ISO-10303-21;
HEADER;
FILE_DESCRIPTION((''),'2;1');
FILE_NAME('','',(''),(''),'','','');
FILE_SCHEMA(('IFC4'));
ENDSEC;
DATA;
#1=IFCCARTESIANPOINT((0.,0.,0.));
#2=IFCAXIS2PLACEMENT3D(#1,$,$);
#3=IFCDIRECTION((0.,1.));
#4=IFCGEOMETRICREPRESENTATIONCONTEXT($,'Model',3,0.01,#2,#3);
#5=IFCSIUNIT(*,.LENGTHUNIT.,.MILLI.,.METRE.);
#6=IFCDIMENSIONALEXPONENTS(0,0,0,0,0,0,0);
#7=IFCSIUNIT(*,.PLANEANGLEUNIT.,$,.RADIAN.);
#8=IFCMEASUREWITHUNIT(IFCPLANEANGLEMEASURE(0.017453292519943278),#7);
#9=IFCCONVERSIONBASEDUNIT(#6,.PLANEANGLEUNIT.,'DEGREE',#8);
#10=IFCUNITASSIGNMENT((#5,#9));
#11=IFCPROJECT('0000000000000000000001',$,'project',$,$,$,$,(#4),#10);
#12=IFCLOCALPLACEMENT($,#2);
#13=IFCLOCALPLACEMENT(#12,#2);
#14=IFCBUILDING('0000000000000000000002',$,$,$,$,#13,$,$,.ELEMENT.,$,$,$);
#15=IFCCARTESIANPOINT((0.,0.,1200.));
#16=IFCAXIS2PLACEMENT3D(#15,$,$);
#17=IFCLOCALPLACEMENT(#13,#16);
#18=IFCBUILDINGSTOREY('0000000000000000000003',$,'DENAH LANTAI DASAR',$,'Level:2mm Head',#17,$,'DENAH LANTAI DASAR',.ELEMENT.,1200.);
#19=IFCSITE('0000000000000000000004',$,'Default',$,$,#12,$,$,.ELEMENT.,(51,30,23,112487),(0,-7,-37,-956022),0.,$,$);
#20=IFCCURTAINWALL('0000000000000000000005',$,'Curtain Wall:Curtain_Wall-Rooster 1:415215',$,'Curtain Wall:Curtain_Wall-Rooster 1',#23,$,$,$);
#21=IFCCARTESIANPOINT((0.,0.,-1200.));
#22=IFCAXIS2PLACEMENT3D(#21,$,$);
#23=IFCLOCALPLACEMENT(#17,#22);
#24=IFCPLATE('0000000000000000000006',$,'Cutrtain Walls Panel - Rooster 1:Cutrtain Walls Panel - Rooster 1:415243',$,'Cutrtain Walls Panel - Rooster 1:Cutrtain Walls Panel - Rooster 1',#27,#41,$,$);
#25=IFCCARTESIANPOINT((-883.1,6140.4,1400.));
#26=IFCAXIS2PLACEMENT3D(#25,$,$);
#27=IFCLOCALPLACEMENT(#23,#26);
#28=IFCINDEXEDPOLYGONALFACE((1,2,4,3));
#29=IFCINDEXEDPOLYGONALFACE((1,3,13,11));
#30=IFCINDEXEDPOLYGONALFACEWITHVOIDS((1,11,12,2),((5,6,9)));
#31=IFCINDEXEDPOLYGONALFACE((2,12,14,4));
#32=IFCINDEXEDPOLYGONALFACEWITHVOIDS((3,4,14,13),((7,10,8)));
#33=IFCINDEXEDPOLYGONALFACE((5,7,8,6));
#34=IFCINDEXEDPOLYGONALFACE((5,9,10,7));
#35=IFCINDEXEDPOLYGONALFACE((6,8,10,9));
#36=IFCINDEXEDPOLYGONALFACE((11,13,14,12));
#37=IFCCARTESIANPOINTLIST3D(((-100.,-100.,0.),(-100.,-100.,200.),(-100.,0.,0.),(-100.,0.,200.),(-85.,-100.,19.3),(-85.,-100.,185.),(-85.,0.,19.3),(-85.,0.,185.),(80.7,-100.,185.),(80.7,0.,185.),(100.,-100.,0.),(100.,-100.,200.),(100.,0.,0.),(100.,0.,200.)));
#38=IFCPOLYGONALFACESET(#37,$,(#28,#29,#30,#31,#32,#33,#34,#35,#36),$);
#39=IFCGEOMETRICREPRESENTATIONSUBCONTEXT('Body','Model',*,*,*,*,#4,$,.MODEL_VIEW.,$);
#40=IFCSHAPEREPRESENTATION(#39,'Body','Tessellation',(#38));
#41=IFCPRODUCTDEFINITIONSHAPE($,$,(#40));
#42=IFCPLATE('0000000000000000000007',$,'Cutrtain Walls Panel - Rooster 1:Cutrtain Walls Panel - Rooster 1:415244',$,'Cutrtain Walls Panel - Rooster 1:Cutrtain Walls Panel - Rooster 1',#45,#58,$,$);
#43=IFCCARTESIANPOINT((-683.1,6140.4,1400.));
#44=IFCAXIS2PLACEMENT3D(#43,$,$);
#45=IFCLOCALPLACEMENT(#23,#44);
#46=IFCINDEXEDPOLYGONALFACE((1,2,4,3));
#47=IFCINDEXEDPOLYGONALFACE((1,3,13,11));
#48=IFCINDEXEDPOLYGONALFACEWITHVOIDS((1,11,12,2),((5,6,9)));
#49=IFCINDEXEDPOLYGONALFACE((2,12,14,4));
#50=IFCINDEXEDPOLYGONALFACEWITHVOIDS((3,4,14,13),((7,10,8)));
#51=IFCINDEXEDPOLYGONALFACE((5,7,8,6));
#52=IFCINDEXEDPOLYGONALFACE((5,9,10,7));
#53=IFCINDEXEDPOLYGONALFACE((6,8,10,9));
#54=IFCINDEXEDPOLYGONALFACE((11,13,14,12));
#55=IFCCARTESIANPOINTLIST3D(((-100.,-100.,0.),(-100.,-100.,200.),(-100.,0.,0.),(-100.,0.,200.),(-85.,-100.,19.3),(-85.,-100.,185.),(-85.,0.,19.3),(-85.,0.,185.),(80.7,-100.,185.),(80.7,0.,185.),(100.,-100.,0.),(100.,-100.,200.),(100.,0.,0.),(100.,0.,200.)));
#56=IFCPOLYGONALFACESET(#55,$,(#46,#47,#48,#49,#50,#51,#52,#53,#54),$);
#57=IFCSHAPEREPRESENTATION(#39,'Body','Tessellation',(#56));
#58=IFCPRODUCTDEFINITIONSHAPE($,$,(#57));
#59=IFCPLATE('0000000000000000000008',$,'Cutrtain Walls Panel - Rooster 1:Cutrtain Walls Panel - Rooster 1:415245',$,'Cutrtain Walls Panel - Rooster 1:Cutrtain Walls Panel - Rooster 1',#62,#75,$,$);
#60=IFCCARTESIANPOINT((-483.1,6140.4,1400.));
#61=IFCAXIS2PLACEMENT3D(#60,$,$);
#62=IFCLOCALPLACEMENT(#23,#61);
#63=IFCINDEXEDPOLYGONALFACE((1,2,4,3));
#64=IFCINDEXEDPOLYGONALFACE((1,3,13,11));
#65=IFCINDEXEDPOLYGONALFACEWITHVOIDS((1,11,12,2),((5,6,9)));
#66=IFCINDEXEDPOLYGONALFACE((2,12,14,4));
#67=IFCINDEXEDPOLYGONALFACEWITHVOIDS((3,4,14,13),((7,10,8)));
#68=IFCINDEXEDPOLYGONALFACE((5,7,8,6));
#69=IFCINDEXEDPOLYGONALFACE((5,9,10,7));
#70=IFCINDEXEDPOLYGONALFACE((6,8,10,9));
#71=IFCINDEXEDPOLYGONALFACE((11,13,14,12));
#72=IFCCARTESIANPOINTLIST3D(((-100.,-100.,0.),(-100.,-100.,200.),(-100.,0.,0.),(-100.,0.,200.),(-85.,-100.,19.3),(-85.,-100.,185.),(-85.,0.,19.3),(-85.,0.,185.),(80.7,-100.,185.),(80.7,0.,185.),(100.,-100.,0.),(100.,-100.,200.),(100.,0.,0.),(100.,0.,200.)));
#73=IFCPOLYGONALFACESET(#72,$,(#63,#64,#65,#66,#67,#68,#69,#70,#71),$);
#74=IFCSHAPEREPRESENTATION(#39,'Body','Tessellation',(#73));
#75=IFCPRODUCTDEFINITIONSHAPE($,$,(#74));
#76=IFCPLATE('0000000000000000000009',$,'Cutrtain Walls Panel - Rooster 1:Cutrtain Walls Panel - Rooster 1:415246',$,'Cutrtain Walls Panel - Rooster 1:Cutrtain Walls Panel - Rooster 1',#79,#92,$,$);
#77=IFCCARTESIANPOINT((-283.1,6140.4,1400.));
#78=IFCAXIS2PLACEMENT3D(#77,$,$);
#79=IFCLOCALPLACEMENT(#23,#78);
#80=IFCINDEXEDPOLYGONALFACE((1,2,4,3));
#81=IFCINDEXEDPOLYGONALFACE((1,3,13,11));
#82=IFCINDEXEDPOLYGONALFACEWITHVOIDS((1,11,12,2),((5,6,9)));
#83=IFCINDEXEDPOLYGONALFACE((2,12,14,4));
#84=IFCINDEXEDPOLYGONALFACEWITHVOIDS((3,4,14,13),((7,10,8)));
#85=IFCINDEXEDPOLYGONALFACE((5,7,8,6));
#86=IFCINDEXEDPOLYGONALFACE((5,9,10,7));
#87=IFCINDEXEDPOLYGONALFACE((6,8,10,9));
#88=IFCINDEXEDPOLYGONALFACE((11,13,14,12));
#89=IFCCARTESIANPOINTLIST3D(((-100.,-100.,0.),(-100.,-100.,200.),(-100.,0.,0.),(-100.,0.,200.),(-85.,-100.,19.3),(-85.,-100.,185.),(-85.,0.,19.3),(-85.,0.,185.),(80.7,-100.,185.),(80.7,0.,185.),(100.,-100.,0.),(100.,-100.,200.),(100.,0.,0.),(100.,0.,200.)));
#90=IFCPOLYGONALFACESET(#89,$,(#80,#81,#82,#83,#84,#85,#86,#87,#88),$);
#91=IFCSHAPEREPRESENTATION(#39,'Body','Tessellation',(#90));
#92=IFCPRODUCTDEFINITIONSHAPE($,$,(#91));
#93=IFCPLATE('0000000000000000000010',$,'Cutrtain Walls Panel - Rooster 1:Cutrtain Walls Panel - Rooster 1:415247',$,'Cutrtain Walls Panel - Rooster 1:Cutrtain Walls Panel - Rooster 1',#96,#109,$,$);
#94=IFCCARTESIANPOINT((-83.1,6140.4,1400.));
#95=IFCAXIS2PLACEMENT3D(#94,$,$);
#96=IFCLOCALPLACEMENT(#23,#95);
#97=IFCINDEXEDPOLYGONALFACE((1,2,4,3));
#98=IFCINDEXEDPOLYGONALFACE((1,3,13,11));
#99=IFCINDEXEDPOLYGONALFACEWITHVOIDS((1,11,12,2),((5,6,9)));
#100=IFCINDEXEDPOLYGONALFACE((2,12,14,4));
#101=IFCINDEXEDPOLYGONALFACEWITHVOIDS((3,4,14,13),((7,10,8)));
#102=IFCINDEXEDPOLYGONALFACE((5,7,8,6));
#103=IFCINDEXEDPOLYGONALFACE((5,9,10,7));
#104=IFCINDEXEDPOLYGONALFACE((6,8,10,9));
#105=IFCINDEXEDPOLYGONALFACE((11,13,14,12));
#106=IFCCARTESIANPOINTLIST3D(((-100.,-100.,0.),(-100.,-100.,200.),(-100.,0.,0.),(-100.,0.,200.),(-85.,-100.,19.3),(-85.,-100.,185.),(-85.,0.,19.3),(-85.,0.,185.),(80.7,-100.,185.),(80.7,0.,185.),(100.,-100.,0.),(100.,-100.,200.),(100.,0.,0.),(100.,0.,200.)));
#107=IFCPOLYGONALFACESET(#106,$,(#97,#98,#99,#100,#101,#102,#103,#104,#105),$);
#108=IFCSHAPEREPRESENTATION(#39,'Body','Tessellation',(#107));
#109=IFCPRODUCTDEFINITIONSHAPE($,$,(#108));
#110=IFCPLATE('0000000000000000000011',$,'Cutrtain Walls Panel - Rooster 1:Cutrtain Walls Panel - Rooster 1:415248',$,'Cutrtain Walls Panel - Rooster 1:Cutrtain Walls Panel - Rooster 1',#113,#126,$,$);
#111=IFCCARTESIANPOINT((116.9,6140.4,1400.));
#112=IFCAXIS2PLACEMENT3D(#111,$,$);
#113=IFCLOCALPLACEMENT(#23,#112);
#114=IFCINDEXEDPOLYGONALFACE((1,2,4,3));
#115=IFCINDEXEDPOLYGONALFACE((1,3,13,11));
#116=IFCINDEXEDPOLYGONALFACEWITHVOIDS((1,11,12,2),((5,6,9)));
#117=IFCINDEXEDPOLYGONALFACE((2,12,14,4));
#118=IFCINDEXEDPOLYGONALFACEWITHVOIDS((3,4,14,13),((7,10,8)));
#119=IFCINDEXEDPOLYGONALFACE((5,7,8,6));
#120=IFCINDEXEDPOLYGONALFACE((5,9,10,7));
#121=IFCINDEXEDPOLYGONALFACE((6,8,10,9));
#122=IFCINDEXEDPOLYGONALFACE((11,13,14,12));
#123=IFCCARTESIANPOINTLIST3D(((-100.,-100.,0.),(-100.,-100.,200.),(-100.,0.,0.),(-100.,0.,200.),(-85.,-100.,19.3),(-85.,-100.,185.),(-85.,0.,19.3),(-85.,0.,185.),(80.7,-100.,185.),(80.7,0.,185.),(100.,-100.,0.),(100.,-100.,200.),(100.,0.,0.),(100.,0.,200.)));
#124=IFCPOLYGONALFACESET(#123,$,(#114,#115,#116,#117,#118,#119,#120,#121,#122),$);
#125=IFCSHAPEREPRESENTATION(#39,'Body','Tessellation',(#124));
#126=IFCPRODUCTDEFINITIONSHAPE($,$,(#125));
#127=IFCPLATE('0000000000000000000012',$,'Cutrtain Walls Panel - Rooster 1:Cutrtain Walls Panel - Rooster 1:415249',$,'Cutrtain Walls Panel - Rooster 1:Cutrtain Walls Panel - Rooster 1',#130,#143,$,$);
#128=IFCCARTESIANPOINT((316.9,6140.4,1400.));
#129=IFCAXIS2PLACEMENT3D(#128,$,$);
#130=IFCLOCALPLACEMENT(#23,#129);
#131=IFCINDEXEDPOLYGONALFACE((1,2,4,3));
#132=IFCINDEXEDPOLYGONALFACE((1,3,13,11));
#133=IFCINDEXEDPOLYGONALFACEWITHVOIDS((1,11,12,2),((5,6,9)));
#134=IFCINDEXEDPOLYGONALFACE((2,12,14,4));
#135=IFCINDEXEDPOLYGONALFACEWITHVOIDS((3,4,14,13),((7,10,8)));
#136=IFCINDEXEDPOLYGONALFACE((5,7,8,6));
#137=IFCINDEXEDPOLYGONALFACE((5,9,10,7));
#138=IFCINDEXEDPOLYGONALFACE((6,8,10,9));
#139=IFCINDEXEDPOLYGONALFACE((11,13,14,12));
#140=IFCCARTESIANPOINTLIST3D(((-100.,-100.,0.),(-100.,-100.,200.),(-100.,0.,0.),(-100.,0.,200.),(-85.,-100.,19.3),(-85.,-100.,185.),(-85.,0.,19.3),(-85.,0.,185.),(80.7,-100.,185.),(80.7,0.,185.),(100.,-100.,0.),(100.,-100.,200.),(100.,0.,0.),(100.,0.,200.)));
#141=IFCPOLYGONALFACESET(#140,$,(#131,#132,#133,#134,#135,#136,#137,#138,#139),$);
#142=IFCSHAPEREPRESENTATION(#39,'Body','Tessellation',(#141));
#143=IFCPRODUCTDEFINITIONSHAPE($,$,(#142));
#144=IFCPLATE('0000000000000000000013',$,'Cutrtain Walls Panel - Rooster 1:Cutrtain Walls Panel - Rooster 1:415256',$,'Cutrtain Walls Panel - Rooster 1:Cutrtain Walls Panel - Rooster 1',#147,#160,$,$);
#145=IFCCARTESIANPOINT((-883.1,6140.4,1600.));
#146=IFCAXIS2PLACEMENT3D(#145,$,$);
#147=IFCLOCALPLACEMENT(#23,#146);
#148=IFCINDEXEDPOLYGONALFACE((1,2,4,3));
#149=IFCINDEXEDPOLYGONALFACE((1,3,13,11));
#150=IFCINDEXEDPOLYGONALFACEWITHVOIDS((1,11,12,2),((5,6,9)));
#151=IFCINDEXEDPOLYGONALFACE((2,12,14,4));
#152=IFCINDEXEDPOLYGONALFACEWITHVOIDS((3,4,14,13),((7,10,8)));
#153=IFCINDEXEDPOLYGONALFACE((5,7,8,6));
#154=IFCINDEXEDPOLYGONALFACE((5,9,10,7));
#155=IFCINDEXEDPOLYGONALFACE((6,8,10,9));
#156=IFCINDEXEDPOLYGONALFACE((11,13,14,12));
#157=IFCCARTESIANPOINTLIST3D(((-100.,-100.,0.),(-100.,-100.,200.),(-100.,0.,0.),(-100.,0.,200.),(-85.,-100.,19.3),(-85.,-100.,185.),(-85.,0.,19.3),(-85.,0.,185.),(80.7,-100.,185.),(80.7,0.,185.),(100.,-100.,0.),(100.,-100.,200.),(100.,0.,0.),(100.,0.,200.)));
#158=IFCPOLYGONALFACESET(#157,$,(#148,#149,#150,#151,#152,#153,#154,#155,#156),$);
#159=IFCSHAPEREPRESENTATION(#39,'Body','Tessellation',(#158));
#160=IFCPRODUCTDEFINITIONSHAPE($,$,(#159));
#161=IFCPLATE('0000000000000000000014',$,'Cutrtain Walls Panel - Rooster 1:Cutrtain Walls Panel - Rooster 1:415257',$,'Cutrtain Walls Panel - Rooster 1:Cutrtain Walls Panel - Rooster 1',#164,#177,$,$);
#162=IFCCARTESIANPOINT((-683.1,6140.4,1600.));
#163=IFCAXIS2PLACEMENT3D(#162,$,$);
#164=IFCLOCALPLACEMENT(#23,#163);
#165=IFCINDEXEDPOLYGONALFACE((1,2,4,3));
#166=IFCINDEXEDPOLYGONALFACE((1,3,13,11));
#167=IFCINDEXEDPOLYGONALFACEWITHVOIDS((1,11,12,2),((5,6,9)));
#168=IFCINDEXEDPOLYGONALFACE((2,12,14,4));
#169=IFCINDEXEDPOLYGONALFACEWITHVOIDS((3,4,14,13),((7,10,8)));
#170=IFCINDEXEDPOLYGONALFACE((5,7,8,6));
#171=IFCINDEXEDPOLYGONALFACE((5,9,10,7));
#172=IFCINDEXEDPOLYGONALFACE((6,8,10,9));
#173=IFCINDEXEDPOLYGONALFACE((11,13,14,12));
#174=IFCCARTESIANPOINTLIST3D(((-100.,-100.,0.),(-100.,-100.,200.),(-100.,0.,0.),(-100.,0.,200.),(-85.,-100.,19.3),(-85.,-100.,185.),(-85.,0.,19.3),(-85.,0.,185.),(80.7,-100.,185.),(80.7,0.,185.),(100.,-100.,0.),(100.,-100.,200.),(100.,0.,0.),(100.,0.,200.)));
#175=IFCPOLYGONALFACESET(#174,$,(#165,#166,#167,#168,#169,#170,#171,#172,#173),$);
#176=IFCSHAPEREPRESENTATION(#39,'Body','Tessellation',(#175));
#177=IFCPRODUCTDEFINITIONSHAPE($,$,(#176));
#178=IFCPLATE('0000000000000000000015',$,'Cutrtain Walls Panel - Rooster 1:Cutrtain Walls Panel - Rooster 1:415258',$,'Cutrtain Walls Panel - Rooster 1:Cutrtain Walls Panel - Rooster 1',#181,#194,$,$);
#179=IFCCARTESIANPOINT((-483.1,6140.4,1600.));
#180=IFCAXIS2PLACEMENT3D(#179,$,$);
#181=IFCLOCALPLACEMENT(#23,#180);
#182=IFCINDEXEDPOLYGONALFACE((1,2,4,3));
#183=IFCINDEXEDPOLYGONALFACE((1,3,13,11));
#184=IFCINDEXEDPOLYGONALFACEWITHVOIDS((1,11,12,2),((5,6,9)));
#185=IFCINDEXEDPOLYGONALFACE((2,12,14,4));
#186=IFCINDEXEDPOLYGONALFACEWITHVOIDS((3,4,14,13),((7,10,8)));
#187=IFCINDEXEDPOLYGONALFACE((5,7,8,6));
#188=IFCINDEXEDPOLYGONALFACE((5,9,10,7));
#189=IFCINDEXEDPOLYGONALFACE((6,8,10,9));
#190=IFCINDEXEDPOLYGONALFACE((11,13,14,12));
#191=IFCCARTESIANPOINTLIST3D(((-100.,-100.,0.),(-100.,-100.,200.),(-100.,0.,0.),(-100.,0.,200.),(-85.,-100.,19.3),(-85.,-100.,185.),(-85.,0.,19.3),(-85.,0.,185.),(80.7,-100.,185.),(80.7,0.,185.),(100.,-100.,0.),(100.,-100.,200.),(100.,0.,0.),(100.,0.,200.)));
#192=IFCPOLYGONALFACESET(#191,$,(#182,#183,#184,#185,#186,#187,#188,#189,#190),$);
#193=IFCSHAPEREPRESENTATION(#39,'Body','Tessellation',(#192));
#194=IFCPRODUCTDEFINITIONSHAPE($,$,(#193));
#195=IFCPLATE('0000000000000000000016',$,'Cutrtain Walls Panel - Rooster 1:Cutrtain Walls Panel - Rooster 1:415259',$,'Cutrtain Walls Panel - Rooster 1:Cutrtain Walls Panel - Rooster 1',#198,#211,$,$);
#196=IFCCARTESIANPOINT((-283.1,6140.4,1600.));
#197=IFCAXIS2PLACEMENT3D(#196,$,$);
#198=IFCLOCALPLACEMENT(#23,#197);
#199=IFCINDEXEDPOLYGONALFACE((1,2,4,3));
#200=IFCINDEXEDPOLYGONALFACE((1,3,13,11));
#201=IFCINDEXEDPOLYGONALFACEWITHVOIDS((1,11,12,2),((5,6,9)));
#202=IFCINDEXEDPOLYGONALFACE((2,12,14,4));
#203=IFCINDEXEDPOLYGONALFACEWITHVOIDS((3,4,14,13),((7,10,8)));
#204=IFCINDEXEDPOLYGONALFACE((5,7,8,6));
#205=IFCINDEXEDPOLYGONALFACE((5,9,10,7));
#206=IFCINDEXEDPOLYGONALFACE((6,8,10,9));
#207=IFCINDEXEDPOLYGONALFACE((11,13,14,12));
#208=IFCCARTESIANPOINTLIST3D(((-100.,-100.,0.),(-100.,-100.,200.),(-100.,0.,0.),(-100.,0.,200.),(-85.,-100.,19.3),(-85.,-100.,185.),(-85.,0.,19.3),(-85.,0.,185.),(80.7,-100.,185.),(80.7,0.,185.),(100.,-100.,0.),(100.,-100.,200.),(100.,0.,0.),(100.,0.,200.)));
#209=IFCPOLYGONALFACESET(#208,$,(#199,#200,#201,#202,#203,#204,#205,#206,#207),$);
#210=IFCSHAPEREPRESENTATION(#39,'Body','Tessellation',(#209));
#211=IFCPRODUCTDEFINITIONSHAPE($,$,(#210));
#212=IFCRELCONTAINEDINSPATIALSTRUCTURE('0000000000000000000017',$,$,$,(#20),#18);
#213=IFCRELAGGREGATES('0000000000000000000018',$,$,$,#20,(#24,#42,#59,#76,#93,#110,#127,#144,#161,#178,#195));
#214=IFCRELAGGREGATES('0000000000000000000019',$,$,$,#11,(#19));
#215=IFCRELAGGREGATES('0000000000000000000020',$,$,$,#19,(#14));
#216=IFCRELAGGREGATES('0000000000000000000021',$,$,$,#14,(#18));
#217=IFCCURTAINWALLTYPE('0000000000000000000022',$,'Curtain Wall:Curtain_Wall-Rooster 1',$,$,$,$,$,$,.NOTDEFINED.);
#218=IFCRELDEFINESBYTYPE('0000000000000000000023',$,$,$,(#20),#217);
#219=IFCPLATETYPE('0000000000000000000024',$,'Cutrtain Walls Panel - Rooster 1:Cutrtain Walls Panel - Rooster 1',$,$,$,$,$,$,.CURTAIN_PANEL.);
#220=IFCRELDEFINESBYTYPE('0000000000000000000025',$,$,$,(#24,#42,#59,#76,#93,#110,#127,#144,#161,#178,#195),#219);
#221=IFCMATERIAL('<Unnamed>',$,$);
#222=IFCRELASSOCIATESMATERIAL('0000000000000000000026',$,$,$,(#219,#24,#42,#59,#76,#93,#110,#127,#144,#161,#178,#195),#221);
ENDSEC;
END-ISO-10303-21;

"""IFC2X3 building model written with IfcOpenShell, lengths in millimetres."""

from ifc_helpers import new_model, entity, si_unit, converted_unit, direction, frame, origin, place, context, subcontext, project, spatial, polyline, outline, extrude, source, transform, mapped, material, type_object, type_shapes, element, aggregate, save


model = new_model("IFC2X3")

# Units and contexts
model_context = context("Model", 3, precision=0.01, world=origin(), true_north=direction((0.0, 1.0)))
body_context = subcontext(model_context, "Body", "Model", "MODEL_VIEW")
ifc_project = project(units=[si_unit("LENGTHUNIT", "METRE", prefix="MILLI"), converted_unit("PLANEANGLEUNIT", "DEGREE", entity("IfcPlaneAngleMeasure", 0.017453292519943278), si_unit("PLANEANGLEUNIT", "RADIAN"), dimensions=[0, 0, 0, 0, 0, 0, 0])], contexts=[model_context])

# Site, building, storey
site_placement = place(None, origin())
site = spatial("IfcSite", under=ifc_project, at=site_placement, Name="Default", CompositionType="ELEMENT", RefLatitude=(51, 30, 23, 112487), RefLongitude=(0, -7, -37, -956022), RefElevation=0.0)
building_placement = place(site_placement, origin())
building = spatial("IfcBuilding", under=site, at=building_placement, CompositionType="ELEMENT")
storey_placement = place(building_placement, frame((0.0, 0.0, 1200.0)))
storey = spatial("IfcBuildingStorey", under=building, at=storey_placement, Name="DENAH LANTAI DASAR", ObjectType="Level:2mm Head", LongName="DENAH LANTAI DASAR", CompositionType="ELEMENT", Elevation=1200.0)

# Curtain wall, plates
curtain_wall_type = type_object("IfcCurtainWallType", Name="Curtain Wall:Curtain_Wall-Rooster 1", PredefinedType="NOTDEFINED")
ifc_material_1 = material(Name="<Unnamed>")
curtain_wall_1_placement = place(storey_placement, frame((0.0, 0.0, -1200.0)))
curtain_wall_1 = element("IfcCurtainWall", 1, at=curtain_wall_1_placement, inside=storey, type_object=curtain_wall_type, Name="Curtain Wall:Curtain_Wall-Rooster 1:415215", ObjectType="Curtain Wall:Curtain_Wall-Rooster 1")
plate_type_1 = type_object("IfcPlateType", Name="Cutrtain Walls Panel - Rooster 1:Cutrtain Walls Panel - Rooster 1", PredefinedType="CURTAIN_PANEL", material=ifc_material_1)
shared_shape_1 = source(origin(), body_context, "Body", "SweptSolid", [
    extrude(outline(polyline([(-100.0, -100.0), (100.0, -100.0), (100.0, 100.0), (-100.0, 100.0), (-100.0, -100.0)]), holes=[polyline([(80.7, 85.0), (-85.0, -80.7), (-85.0, 85.0), (80.7, 85.0)])]), frame((0.0, -100.0, 100.0), z_axis=(0.0, 1.0, 0.0), x_axis=(0.0, 0.0, -1.0)), (0.0, 0.0, 1.0), 100.0),
])
type_shapes(plate_type_1, [shared_shape_1])
plate_1_placement = place(curtain_wall_1_placement, frame((-883.1, 6140.4, 1400.0)))
plate_1 = element("IfcPlate", 2, at=plate_1_placement, type_object=plate_type_1, material=ifc_material_1, Name="Cutrtain Walls Panel - Rooster 1:Cutrtain Walls Panel - Rooster 1:415243", ObjectType="Cutrtain Walls Panel - Rooster 1:Cutrtain Walls Panel - Rooster 1", context=body_context, shape_type="MappedRepresentation", body=[
    mapped(shared_shape_1, transform((0.0, 0.0, 0.0), scale=1.0)),
])
plate_2_placement = place(curtain_wall_1_placement, frame((-683.1, 6140.4, 1400.0)))
plate_2 = element("IfcPlate", 3, at=plate_2_placement, type_object=plate_type_1, material=ifc_material_1, Name="Cutrtain Walls Panel - Rooster 1:Cutrtain Walls Panel - Rooster 1:415244", ObjectType="Cutrtain Walls Panel - Rooster 1:Cutrtain Walls Panel - Rooster 1", context=body_context, shape_type="MappedRepresentation", body=[
    mapped(shared_shape_1, transform((0.0, 0.0, 0.0), scale=1.0)),
])
plate_3_placement = place(curtain_wall_1_placement, frame((-483.1, 6140.4, 1400.0)))
plate_3 = element("IfcPlate", 4, at=plate_3_placement, type_object=plate_type_1, material=ifc_material_1, Name="Cutrtain Walls Panel - Rooster 1:Cutrtain Walls Panel - Rooster 1:415245", ObjectType="Cutrtain Walls Panel - Rooster 1:Cutrtain Walls Panel - Rooster 1", context=body_context, shape_type="MappedRepresentation", body=[
    mapped(shared_shape_1, transform((0.0, 0.0, 0.0), scale=1.0)),
])
plate_4_placement = place(curtain_wall_1_placement, frame((-283.1, 6140.4, 1400.0)))
plate_4 = element("IfcPlate", 5, at=plate_4_placement, type_object=plate_type_1, material=ifc_material_1, Name="Cutrtain Walls Panel - Rooster 1:Cutrtain Walls Panel - Rooster 1:415246", ObjectType="Cutrtain Walls Panel - Rooster 1:Cutrtain Walls Panel - Rooster 1", context=body_context, shape_type="MappedRepresentation", body=[
    mapped(shared_shape_1, transform((0.0, 0.0, 0.0), scale=1.0)),
])
plate_5_placement = place(curtain_wall_1_placement, frame((-83.1, 6140.4, 1400.0)))
plate_5 = element("IfcPlate", 6, at=plate_5_placement, type_object=plate_type_1, material=ifc_material_1, Name="Cutrtain Walls Panel - Rooster 1:Cutrtain Walls Panel - Rooster 1:415247", ObjectType="Cutrtain Walls Panel - Rooster 1:Cutrtain Walls Panel - Rooster 1", context=body_context, shape_type="MappedRepresentation", body=[
    mapped(shared_shape_1, transform((0.0, 0.0, 0.0), scale=1.0)),
])
plate_6_placement = place(curtain_wall_1_placement, frame((116.9, 6140.4, 1400.0)))
plate_6 = element("IfcPlate", 7, at=plate_6_placement, type_object=plate_type_1, material=ifc_material_1, Name="Cutrtain Walls Panel - Rooster 1:Cutrtain Walls Panel - Rooster 1:415248", ObjectType="Cutrtain Walls Panel - Rooster 1:Cutrtain Walls Panel - Rooster 1", context=body_context, shape_type="MappedRepresentation", body=[
    mapped(shared_shape_1, transform((0.0, 0.0, 0.0), scale=1.0)),
])
plate_7_placement = place(curtain_wall_1_placement, frame((316.9, 6140.4, 1400.0)))
plate_7 = element("IfcPlate", 8, at=plate_7_placement, type_object=plate_type_1, material=ifc_material_1, Name="Cutrtain Walls Panel - Rooster 1:Cutrtain Walls Panel - Rooster 1:415249", ObjectType="Cutrtain Walls Panel - Rooster 1:Cutrtain Walls Panel - Rooster 1", context=body_context, shape_type="MappedRepresentation", body=[
    mapped(shared_shape_1, transform((0.0, 0.0, 0.0), scale=1.0)),
])
plate_8_placement = place(curtain_wall_1_placement, frame((-883.1, 6140.4, 1600.0)))
plate_8 = element("IfcPlate", 9, at=plate_8_placement, type_object=plate_type_1, material=ifc_material_1, Name="Cutrtain Walls Panel - Rooster 1:Cutrtain Walls Panel - Rooster 1:415256", ObjectType="Cutrtain Walls Panel - Rooster 1:Cutrtain Walls Panel - Rooster 1", context=body_context, shape_type="MappedRepresentation", body=[
    mapped(shared_shape_1, transform((0.0, 0.0, 0.0), scale=1.0)),
])
plate_9_placement = place(curtain_wall_1_placement, frame((-683.1, 6140.4, 1600.0)))
plate_9 = element("IfcPlate", 10, at=plate_9_placement, type_object=plate_type_1, material=ifc_material_1, Name="Cutrtain Walls Panel - Rooster 1:Cutrtain Walls Panel - Rooster 1:415257", ObjectType="Cutrtain Walls Panel - Rooster 1:Cutrtain Walls Panel - Rooster 1", context=body_context, shape_type="MappedRepresentation", body=[
    mapped(shared_shape_1, transform((0.0, 0.0, 0.0), scale=1.0)),
])
plate_10_placement = place(curtain_wall_1_placement, frame((-483.1, 6140.4, 1600.0)))
plate_10 = element("IfcPlate", 11, at=plate_10_placement, type_object=plate_type_1, material=ifc_material_1, Name="Cutrtain Walls Panel - Rooster 1:Cutrtain Walls Panel - Rooster 1:415258", ObjectType="Cutrtain Walls Panel - Rooster 1:Cutrtain Walls Panel - Rooster 1", context=body_context, shape_type="MappedRepresentation", body=[
    mapped(shared_shape_1, transform((0.0, 0.0, 0.0), scale=1.0)),
])
plate_11_placement = place(curtain_wall_1_placement, frame((-283.1, 6140.4, 1600.0)))
plate_11 = element("IfcPlate", 12, at=plate_11_placement, type_object=plate_type_1, material=ifc_material_1, Name="Cutrtain Walls Panel - Rooster 1:Cutrtain Walls Panel - Rooster 1:415259", ObjectType="Cutrtain Walls Panel - Rooster 1:Cutrtain Walls Panel - Rooster 1", context=body_context, shape_type="MappedRepresentation", body=[
    mapped(shared_shape_1, transform((0.0, 0.0, 0.0), scale=1.0)),
])
aggregate(curtain_wall_1, [plate_1, plate_2, plate_3, plate_4, plate_5, plate_6, plate_7, plate_8, plate_9, plate_10, plate_11])

save(model, "model.ifc")
